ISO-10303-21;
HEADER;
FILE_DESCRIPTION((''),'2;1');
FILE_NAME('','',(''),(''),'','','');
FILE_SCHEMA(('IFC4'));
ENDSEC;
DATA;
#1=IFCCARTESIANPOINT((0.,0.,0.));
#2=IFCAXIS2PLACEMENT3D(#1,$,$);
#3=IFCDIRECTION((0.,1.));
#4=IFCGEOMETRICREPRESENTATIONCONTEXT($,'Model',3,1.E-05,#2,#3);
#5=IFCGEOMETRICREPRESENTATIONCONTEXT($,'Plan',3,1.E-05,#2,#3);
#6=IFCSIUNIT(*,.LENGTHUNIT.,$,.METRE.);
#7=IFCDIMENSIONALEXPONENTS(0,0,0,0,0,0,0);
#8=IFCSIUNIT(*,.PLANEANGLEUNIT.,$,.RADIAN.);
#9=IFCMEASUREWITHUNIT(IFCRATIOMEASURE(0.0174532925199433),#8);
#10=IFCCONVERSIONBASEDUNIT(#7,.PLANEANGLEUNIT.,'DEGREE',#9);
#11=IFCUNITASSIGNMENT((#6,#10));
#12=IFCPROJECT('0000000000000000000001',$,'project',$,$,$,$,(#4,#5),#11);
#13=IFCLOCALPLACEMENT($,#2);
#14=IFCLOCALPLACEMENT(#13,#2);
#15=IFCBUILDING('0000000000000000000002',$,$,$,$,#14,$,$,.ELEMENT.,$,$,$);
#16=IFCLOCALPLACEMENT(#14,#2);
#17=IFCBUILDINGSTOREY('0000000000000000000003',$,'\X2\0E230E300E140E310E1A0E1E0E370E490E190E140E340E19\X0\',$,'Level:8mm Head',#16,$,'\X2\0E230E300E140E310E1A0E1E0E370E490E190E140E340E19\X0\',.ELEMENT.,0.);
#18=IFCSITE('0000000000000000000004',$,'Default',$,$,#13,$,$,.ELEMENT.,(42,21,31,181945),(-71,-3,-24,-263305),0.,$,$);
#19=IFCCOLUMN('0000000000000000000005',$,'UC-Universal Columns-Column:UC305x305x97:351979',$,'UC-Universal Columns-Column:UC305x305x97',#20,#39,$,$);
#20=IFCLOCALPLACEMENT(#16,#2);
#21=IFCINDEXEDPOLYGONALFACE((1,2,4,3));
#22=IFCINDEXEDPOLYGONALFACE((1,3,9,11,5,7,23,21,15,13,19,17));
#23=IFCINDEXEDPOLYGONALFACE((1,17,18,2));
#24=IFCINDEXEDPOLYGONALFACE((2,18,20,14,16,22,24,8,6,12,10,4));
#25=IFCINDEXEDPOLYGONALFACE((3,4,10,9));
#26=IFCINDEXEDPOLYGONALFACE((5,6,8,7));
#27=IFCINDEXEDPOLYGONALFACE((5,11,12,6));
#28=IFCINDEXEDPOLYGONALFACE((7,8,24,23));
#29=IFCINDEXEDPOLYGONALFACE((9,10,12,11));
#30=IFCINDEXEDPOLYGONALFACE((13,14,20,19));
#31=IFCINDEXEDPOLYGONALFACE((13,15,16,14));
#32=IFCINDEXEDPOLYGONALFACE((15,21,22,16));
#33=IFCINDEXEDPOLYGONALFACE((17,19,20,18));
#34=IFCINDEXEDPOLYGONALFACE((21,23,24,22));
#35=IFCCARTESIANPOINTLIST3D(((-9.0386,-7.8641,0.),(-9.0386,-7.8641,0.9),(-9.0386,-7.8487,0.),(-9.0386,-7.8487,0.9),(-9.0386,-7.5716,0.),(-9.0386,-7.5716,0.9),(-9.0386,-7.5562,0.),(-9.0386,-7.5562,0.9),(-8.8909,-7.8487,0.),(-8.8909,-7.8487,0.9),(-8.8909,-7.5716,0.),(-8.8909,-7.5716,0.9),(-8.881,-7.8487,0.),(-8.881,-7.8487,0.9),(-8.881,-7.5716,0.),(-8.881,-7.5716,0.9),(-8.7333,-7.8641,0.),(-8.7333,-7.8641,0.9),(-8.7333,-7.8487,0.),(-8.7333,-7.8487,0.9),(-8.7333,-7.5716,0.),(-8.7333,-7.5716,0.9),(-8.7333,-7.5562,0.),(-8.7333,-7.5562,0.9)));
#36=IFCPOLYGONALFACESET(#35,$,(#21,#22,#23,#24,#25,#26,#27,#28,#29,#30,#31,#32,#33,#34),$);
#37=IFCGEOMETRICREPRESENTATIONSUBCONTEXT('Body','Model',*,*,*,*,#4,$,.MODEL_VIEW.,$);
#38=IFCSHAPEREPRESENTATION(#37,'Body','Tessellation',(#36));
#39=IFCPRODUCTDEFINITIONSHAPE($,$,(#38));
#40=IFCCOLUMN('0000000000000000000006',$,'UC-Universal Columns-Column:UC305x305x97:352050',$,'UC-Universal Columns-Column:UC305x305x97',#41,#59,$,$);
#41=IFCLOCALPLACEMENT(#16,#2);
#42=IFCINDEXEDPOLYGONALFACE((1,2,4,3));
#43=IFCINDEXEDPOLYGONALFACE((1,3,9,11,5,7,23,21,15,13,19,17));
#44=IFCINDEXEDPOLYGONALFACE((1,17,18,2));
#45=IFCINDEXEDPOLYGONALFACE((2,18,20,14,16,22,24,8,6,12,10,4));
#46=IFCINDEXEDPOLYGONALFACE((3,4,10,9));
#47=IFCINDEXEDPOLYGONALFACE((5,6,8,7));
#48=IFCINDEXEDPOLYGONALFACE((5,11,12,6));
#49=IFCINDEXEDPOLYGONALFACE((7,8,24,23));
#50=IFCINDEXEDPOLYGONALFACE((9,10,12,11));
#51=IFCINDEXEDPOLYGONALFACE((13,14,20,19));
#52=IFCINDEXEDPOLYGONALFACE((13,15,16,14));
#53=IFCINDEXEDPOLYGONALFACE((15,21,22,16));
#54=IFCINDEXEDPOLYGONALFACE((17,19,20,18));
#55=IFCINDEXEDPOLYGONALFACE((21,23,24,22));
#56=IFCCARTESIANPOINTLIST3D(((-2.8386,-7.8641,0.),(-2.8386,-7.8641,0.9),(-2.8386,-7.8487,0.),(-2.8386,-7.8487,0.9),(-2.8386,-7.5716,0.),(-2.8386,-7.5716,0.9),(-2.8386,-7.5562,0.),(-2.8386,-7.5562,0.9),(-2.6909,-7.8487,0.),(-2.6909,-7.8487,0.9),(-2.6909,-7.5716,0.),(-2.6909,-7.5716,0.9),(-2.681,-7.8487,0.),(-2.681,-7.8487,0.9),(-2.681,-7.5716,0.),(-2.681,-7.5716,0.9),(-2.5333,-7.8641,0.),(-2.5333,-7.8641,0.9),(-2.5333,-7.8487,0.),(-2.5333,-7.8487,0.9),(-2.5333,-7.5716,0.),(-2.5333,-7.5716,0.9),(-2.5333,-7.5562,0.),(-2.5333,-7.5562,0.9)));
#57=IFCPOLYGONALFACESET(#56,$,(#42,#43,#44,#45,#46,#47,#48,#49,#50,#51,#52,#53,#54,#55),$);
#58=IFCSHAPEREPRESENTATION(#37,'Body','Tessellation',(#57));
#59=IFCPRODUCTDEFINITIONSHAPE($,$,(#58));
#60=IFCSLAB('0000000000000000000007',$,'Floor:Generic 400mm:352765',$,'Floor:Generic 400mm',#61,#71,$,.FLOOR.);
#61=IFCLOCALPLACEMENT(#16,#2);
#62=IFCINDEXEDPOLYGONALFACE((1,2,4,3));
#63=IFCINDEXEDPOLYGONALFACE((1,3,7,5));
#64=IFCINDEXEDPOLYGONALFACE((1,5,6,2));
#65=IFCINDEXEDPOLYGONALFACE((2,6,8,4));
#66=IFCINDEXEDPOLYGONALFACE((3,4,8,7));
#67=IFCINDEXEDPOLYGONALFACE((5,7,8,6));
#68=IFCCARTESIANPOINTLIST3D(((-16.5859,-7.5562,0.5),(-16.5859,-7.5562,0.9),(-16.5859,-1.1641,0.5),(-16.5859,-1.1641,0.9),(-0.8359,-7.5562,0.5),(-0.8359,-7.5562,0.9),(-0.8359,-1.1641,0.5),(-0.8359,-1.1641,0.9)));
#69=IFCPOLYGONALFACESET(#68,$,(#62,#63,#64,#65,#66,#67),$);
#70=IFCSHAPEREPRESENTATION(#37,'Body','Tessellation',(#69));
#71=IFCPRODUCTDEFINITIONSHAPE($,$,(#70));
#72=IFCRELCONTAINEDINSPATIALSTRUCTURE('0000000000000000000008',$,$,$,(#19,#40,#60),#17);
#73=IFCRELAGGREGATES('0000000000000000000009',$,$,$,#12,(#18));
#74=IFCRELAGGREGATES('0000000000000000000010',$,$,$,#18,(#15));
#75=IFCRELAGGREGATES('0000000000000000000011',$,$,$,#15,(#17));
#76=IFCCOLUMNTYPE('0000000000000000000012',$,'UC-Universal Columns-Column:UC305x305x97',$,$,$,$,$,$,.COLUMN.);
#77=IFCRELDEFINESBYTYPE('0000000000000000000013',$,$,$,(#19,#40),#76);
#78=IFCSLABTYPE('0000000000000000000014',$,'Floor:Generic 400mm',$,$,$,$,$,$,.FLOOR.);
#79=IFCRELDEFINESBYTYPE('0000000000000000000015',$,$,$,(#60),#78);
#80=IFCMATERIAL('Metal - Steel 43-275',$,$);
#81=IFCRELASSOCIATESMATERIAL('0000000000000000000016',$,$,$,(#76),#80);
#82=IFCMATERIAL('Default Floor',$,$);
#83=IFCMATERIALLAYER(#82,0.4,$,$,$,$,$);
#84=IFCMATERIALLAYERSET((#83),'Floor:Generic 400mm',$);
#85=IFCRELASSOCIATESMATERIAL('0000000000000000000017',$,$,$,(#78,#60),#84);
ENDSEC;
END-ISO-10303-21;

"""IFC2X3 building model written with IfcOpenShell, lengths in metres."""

from ifc_helpers import new_model, entity, si_unit, converted_unit, direction, frame, frame_2d, origin, place, context, subcontext, project, spatial, rectangle, i_section, extrude, source, transform, mapped, material, layer, layer_set, layer_usage, type_object, type_shapes, element, save


model = new_model("IFC2X3")

# Units and contexts
model_context = context("Model", 3, precision=1e-05, world=origin(), true_north=direction((0.0, 1.0)))
plan_context = context("Plan", 3, precision=1e-05, world=origin(), true_north=direction((0.0, 1.0)))
body_context = subcontext(model_context, "Body", "Model", "MODEL_VIEW")
ifc_project = project(units=[si_unit("LENGTHUNIT", "METRE"), converted_unit("PLANEANGLEUNIT", "DEGREE", entity("IfcRatioMeasure", 0.0174532925199433), si_unit("PLANEANGLEUNIT", "RADIAN"), dimensions=[0, 0, 0, 0, 0, 0, 0])], contexts=[model_context, plan_context])

# Site, building, storey
site_placement = place(None, origin())
site = spatial("IfcSite", under=ifc_project, at=site_placement, Name="Default", CompositionType="ELEMENT", RefLatitude=(42, 21, 31, 181945), RefLongitude=(-71, -3, -24, -263305), RefElevation=0.0)
building_placement = place(site_placement, origin())
building = spatial("IfcBuilding", under=site, at=building_placement, CompositionType="ELEMENT")
storey_placement = place(building_placement, origin())
storey = spatial("IfcBuildingStorey", under=building, at=storey_placement, Name="ระดับพื้นดิน", ObjectType="Level:8mm Head", LongName="ระดับพื้นดิน", CompositionType="ELEMENT", Elevation=0.0)

# Columns
ifc_material_1 = material(Name="Metal - Steel 43-275")
column_type_1 = type_object("IfcColumnType", Name="UC-Universal Columns-Column:UC305x305x97", PredefinedType="COLUMN", material=ifc_material_1)
shared_shape_1 = source(origin(), body_context, "Body", "SweptSolid", [
    extrude(i_section(OverallWidth=0.3053, OverallDepth=0.3079, WebThickness=0.0099, FlangeThickness=0.0154, at=frame_2d((0.0, 0.0), x_axis=(0.0, 1.0))), frame((0.0, 0.0, 0.0), z_axis=(0.0, 0.0, 1.0), x_axis=(0.0, -1.0, 0.0)), (0.0, 0.0, 1.0), 0.9),
])
type_shapes(column_type_1, [shared_shape_1])
for number, where, name in (
    (1, (-8.8859, -7.7102, 0.0), "UC-Universal Columns-Column:UC305x305x97:351979"),
    (2, (-2.6859, -7.7102, 0.0), "UC-Universal Columns-Column:UC305x305x97:352050"),
):
    element("IfcColumn", number, at=place(storey_placement, frame(where)), inside=storey, type_object=column_type_1, Name=name, ObjectType="UC-Universal Columns-Column:UC305x305x97", context=body_context, shape_type="MappedRepresentation", body=[
        mapped(shared_shape_1, transform((0.0, 0.0, 0.0), scale=1.0)),
    ])

# Slab
ifc_material_2 = material(Name="Default Floor")
ifc_layer = layer(ifc_material_2, 0.4)
ifc_layer_set = layer_set([ifc_layer], Name="Floor:Generic 400mm")
ifc_layer_usage = layer_usage(ifc_layer_set, "AXIS3", "POSITIVE", 0.0)
slab_type = type_object("IfcSlabType", Name="Floor:Generic 400mm", PredefinedType="FLOOR", material=ifc_layer_set)
slab_placement = place(storey_placement, origin())
element("IfcSlab", 3, at=slab_placement, inside=storey, type_object=slab_type, material=ifc_layer_usage, Name="Floor:Generic 400mm:352765", ObjectType="Floor:Generic 400mm", PredefinedType="FLOOR", context=body_context, shape_type="SweptSolid", body=[
    extrude(rectangle(XDim=6.3921, YDim=15.75, at=frame_2d((0.0, 0.0), x_axis=(1.0, 0.0))), frame((-8.7109, -4.3602, 0.9), z_axis=(0.0, 0.0, -1.0), x_axis=(0.0, 1.0, 0.0)), (0.0, 0.0, 1.0), 0.4),
])

save(model, "model.ifc")
